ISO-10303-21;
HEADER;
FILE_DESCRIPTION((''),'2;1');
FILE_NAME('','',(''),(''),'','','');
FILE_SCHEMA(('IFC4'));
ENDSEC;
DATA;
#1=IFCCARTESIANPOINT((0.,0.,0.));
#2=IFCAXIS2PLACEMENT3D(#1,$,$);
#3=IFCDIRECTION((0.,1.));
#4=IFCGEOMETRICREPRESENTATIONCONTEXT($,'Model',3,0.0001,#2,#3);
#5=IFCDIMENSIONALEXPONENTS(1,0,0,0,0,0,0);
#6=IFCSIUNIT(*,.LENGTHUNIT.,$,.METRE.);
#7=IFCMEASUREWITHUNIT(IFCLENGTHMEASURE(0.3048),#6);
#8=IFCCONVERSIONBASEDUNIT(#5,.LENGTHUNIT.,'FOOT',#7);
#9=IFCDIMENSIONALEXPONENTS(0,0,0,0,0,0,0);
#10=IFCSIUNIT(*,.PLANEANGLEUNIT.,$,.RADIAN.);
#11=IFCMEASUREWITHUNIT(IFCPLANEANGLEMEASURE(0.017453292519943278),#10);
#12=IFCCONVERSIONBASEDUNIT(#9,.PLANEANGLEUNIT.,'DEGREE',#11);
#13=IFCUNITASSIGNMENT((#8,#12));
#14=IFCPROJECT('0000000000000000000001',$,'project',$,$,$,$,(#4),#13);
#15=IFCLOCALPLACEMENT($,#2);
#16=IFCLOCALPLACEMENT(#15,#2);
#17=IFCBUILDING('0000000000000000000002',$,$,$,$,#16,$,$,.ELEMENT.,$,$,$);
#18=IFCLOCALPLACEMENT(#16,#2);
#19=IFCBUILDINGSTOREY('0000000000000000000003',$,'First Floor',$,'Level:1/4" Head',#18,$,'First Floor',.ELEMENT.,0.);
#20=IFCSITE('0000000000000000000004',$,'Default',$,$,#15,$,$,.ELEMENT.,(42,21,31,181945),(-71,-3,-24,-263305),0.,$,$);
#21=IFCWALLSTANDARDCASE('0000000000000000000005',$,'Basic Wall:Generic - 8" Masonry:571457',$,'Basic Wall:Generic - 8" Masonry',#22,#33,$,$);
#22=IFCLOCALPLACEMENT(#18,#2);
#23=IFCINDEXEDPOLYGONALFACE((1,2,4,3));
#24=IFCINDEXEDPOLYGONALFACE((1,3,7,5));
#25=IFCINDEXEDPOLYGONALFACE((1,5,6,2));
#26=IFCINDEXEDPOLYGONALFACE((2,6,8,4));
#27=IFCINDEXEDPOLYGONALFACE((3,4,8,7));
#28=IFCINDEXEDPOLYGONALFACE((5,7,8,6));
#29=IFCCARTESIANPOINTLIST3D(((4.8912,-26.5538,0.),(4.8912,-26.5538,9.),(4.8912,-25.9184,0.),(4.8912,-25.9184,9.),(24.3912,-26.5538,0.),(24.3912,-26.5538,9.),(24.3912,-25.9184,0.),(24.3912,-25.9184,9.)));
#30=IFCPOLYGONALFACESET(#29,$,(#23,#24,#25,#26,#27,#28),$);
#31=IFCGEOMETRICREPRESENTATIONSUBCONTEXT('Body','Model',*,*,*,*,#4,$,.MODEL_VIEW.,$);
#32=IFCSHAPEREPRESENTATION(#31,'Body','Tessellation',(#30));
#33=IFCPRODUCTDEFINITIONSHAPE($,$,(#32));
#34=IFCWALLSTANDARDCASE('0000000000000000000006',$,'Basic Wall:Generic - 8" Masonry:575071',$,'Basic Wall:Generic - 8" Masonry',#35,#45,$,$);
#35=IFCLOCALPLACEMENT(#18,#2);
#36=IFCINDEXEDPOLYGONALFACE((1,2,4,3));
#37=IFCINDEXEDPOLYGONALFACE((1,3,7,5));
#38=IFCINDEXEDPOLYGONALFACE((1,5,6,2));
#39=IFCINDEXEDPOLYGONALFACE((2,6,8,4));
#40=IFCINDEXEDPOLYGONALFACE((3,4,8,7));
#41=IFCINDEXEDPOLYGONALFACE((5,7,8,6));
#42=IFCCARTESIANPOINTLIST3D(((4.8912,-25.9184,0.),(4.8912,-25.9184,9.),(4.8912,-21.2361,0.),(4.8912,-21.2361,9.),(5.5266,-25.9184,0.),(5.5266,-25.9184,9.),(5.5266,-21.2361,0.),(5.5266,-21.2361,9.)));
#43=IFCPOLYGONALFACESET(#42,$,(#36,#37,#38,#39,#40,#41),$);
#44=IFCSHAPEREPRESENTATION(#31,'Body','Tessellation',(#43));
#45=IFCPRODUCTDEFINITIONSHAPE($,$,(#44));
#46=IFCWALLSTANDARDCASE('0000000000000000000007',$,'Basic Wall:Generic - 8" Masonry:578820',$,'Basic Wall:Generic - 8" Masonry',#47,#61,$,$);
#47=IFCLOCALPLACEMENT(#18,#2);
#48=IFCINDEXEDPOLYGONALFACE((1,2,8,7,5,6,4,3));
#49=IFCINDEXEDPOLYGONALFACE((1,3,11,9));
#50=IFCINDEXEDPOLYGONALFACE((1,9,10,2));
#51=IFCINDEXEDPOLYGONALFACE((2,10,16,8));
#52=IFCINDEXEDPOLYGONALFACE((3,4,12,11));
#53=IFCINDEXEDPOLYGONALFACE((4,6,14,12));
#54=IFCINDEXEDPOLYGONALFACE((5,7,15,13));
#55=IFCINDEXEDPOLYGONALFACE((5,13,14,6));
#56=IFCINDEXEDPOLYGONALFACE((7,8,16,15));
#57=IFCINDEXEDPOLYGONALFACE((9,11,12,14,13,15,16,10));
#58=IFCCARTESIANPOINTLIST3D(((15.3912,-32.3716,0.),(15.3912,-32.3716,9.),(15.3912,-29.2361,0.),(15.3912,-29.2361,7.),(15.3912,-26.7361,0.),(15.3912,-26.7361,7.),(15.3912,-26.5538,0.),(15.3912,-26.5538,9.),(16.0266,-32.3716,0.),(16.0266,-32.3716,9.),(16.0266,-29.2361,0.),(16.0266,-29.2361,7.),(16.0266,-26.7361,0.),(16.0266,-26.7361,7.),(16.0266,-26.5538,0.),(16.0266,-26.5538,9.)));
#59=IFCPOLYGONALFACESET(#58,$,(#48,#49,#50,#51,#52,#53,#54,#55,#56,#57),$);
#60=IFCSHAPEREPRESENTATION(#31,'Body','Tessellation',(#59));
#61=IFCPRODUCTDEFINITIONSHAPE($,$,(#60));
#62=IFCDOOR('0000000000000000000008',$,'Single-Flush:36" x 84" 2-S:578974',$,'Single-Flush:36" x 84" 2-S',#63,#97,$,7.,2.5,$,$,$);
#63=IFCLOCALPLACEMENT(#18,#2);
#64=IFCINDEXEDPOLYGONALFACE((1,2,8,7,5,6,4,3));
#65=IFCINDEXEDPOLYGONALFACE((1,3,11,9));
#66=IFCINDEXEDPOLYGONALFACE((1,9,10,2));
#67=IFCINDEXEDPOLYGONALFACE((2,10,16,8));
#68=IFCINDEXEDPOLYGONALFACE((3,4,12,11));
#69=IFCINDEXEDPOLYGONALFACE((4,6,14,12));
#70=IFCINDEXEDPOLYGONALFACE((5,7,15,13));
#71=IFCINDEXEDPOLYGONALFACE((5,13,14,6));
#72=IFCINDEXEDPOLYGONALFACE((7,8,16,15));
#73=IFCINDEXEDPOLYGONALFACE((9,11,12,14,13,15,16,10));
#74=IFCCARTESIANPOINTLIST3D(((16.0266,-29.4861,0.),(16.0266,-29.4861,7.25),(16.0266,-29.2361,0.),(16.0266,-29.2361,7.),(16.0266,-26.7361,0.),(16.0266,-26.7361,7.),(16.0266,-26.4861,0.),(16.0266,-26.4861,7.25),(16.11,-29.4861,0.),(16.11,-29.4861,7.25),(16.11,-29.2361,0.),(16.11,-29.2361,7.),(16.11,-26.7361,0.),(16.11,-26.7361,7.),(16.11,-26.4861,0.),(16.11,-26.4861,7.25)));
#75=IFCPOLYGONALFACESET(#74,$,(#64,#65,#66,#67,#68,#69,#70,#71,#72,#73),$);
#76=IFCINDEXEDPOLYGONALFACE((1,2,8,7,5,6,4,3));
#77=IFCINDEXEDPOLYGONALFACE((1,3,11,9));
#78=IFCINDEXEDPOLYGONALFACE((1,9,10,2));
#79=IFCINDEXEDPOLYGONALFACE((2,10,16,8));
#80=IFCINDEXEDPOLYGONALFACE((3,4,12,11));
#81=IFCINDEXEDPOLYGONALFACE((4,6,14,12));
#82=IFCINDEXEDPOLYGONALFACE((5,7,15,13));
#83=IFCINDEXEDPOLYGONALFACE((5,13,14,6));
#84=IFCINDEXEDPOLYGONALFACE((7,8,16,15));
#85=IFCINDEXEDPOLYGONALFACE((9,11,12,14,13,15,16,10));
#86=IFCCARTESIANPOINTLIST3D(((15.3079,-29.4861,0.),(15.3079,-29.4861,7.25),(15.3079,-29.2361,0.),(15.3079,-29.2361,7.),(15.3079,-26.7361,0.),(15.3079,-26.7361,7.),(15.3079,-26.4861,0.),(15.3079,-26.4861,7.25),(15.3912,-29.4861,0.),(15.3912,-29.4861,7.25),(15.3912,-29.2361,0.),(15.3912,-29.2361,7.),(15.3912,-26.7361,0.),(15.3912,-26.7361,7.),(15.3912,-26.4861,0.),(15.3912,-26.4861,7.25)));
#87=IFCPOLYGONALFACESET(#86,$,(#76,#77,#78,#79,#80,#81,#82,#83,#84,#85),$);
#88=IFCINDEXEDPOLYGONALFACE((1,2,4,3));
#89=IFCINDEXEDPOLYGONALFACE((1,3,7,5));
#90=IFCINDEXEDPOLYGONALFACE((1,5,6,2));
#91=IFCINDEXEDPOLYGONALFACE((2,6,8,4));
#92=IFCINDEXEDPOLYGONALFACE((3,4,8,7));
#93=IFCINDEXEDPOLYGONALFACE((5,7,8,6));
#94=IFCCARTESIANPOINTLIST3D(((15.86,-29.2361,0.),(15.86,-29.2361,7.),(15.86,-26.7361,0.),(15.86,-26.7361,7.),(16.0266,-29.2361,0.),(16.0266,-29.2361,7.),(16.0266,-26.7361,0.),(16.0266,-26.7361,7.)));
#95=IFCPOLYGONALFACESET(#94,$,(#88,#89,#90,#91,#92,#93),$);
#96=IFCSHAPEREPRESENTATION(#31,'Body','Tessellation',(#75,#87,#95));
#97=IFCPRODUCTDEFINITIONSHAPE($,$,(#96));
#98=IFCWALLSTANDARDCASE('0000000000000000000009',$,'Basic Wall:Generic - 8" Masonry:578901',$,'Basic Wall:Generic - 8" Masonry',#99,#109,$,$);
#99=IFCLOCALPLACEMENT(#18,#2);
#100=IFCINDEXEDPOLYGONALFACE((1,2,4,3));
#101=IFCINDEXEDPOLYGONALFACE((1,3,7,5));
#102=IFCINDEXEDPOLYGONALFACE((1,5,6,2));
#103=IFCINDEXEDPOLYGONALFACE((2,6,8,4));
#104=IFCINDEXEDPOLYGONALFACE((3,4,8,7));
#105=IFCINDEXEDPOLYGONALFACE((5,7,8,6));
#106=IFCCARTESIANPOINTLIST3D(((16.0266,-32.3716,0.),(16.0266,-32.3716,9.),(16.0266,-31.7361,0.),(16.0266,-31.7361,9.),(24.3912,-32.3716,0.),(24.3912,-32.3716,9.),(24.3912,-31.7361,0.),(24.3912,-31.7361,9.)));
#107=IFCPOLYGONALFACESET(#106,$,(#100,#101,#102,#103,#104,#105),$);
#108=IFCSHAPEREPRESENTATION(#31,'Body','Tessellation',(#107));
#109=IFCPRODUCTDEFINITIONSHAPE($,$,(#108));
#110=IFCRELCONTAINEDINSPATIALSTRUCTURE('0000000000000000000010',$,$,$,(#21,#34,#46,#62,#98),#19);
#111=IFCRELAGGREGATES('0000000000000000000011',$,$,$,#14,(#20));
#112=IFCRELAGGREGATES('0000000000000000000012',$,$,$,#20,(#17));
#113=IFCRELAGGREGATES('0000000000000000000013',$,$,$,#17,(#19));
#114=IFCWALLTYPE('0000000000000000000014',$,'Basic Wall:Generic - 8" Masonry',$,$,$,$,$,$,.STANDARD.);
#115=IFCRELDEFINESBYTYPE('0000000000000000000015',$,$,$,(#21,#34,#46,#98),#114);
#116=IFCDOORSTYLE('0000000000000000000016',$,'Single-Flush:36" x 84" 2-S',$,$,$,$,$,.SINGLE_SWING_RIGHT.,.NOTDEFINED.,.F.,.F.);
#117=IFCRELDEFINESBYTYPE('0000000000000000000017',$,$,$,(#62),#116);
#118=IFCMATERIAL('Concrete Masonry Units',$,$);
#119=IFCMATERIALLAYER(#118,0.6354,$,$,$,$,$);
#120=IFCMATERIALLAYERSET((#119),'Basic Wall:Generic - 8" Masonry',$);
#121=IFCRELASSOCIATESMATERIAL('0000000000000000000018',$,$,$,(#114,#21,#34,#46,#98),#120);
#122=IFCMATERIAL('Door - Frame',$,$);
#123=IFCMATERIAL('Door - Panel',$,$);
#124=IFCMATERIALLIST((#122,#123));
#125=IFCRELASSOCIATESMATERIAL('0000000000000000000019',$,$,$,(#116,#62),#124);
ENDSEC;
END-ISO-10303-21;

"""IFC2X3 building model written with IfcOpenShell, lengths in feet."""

from ifc_helpers import new_model, entity, si_unit, converted_unit, direction, frame, frame_2d, origin, place, context, subcontext, project, spatial, polyline, rectangle, outline, extrude, source, transform, mapped, material, material_list, layer, layer_set, layer_usage, type_object, type_shapes, element, fill, save


model = new_model("IFC2X3")

# Units and contexts
model_context = context("Model", 3, precision=0.0001, world=origin(), true_north=direction((0.0, 1.0)))
body_context = subcontext(model_context, "Body", "Model", "MODEL_VIEW")
ifc_project = project(units=[converted_unit("LENGTHUNIT", "FOOT", entity("IfcLengthMeasure", 0.3048), si_unit("LENGTHUNIT", "METRE"), dimensions=[1, 0, 0, 0, 0, 0, 0]), converted_unit("PLANEANGLEUNIT", "DEGREE", entity("IfcPlaneAngleMeasure", 0.017453292519943278), si_unit("PLANEANGLEUNIT", "RADIAN"), dimensions=[0, 0, 0, 0, 0, 0, 0])], contexts=[model_context])

# Site, building, storey
site_placement = place(None, origin())
site = spatial("IfcSite", under=ifc_project, at=site_placement, Name="Default", CompositionType="ELEMENT", RefLatitude=(42, 21, 31, 181945), RefLongitude=(-71, -3, -24, -263305), RefElevation=0.0)
building_placement = place(site_placement, origin())
building = spatial("IfcBuilding", under=site, at=building_placement, CompositionType="ELEMENT")
storey_placement = place(building_placement, origin())
storey = spatial("IfcBuildingStorey", under=building, at=storey_placement, Name="First Floor", ObjectType="Level:1/4\" Head", LongName="First Floor", CompositionType="ELEMENT", Elevation=0.0)

# Shared definitions
ifc_material_1 = material(Name="Concrete Masonry Units")
ifc_layer = layer(ifc_material_1, 0.6354)
ifc_layer_set = layer_set([ifc_layer], Name="Basic Wall:Generic - 8\" Masonry")
wall_type = type_object("IfcWallType", Name="Basic Wall:Generic - 8\" Masonry", PredefinedType="STANDARD", material=ifc_layer_set)
ifc_material_2 = material(Name="Door - Frame")
ifc_material_3 = material(Name="Door - Panel")

# Walls
ifc_layer_usage_1 = layer_usage(ifc_layer_set, "AXIS2", "NEGATIVE", 0.3177)
wall_1_placement = place(storey_placement, frame((4.8912, -26.2361, 0.0)))
element("IfcWallStandardCase", 1, at=wall_1_placement, inside=storey, type_object=wall_type, material=ifc_layer_usage_1, Name="Basic Wall:Generic - 8\" Masonry:571457", ObjectType="Basic Wall:Generic - 8\" Masonry", context=body_context, shape_type="SweptSolid", body=[
    extrude(rectangle(XDim=19.5, YDim=0.6354, at=frame_2d((9.75, 0.0), x_axis=(-1.0, 0.0))), origin(), (0.0, 0.0, 1.0), 9.0),
])
ifc_layer_usage_2 = layer_usage(ifc_layer_set, "AXIS2", "NEGATIVE", 0.3177)
wall_2_placement = place(storey_placement, frame((5.2089, -25.9184, 0.0), z_axis=(0.0, 0.0, 1.0), x_axis=(0.0, 1.0, 0.0)))
element("IfcWallStandardCase", 2, at=wall_2_placement, inside=storey, type_object=wall_type, material=ifc_layer_usage_2, Name="Basic Wall:Generic - 8\" Masonry:575071", ObjectType="Basic Wall:Generic - 8\" Masonry", context=body_context, shape_type="SweptSolid", body=[
    extrude(rectangle(XDim=4.6823, YDim=0.6354, at=frame_2d((2.3411, 0.0), x_axis=(-1.0, 0.0))), origin(), (0.0, 0.0, 1.0), 9.0),
])

# Wall, opening, door
ifc_layer_usage_3 = layer_usage(ifc_layer_set, "AXIS2", "NEGATIVE", 0.3177)
wall_3_placement = place(storey_placement, frame((15.7089, -26.5538, 0.0), z_axis=(0.0, 0.0, 1.0), x_axis=(0.0, -1.0, 0.0)))
wall_3 = element("IfcWallStandardCase", 3, at=wall_3_placement, inside=storey, type_object=wall_type, material=ifc_layer_usage_3, Name="Basic Wall:Generic - 8\" Masonry:578820", ObjectType="Basic Wall:Generic - 8\" Masonry", context=body_context, shape_type="SweptSolid", body=[
    extrude(rectangle(XDim=5.8177, YDim=0.6354, at=frame_2d((2.9089, 0.0), x_axis=(-1.0, 0.0))), origin(), (0.0, 0.0, 1.0), 9.0),
])
opening_1_placement = place(wall_3_placement, frame((0.1823, -0.3177, 0.0)))
opening_1 = element("IfcOpeningElement", 4, at=opening_1_placement, cuts=wall_3, ObjectType="Opening", context=body_context, shape_type="SweptSolid", body=[
    extrude(rectangle(XDim=2.5, YDim=7.0, at=frame_2d((3.5, 1.25), x_axis=(0.0, 1.0))), frame((0.0, 0.0, 0.0), z_axis=(0.0, 1.0, 0.0), x_axis=(0.0, 0.0, 1.0)), (0.0, 0.0, 1.0), 0.6354),
])
ifc_material_list_1 = material_list([ifc_material_2, ifc_material_3])
door_style_1 = type_object("IfcDoorStyle", Name="Single-Flush:36\" x 84\" 2-S", ConstructionType="NOTDEFINED", OperationType="SINGLE_SWING_RIGHT", ParameterTakesPrecedence=False, Sizeable=False, material=ifc_material_list_1)
shared_shape_1 = source(origin(), body_context, "Body", "SweptSolid", [
    extrude(outline(polyline([(-1.5, -3.6875), (1.5, -3.6875), (1.5, 3.5625), (1.25, 3.5625), (1.25, -3.4375), (-1.25, -3.4375), (-1.25, 3.5625), (-1.5, 3.5625), (-1.5, -3.6875)])), frame((1.25, 0.6354, 3.5625), z_axis=(0.0, 1.0, 0.0), x_axis=(1.0, 0.0, 0.0)), (0.0, 0.0, 1.0), 0.0833),
    extrude(outline(polyline([(-3.6875, -1.5), (3.5625, -1.5), (3.5625, -1.25), (-3.4375, -1.25), (-3.4375, 1.25), (3.5625, 1.25), (3.5625, 1.5), (-3.6875, 1.5), (-3.6875, -1.5)])), frame((1.25, -0.0833, 3.5625), z_axis=(0.0, 1.0, 0.0), x_axis=(0.0, 0.0, -1.0)), (0.0, 0.0, 1.0), 0.0833),
    extrude(rectangle(XDim=0.1667, YDim=2.5, at=frame_2d((0.0, 0.0), x_axis=(1.0, 0.0))), frame((1.25, 0.5521, 0.0), z_axis=(0.0, 0.0, 1.0), x_axis=(0.0, 1.0, 0.0)), (0.0, 0.0, 1.0), 7.0),
])
type_shapes(door_style_1, [shared_shape_1])
door_1_placement = place(opening_1_placement, origin())
door_1 = element("IfcDoor", 5, at=door_1_placement, inside=storey, type_object=door_style_1, material=ifc_material_list_1, Name="Single-Flush:36\" x 84\" 2-S:578974", ObjectType="Single-Flush:36\" x 84\" 2-S", OverallHeight=7.0, OverallWidth=2.5, context=body_context, shape_type="MappedRepresentation", body=[
    mapped(shared_shape_1, transform((0.0, 0.0, 0.0), scale=1.0)),
])
fill(opening_1, door_1)

# Wall
ifc_layer_usage_4 = layer_usage(ifc_layer_set, "AXIS2", "NEGATIVE", 0.3177)
wall_4_placement = place(storey_placement, frame((16.0266, -32.0538, 0.0)))
element("IfcWallStandardCase", 6, at=wall_4_placement, inside=storey, type_object=wall_type, material=ifc_layer_usage_4, Name="Basic Wall:Generic - 8\" Masonry:578901", ObjectType="Basic Wall:Generic - 8\" Masonry", context=body_context, shape_type="SweptSolid", body=[
    extrude(rectangle(XDim=8.3646, YDim=0.6354, at=frame_2d((4.1823, 0.0), x_axis=(-1.0, 0.0))), origin(), (0.0, 0.0, 1.0), 9.0),
])

save(model, "model.ifc")
